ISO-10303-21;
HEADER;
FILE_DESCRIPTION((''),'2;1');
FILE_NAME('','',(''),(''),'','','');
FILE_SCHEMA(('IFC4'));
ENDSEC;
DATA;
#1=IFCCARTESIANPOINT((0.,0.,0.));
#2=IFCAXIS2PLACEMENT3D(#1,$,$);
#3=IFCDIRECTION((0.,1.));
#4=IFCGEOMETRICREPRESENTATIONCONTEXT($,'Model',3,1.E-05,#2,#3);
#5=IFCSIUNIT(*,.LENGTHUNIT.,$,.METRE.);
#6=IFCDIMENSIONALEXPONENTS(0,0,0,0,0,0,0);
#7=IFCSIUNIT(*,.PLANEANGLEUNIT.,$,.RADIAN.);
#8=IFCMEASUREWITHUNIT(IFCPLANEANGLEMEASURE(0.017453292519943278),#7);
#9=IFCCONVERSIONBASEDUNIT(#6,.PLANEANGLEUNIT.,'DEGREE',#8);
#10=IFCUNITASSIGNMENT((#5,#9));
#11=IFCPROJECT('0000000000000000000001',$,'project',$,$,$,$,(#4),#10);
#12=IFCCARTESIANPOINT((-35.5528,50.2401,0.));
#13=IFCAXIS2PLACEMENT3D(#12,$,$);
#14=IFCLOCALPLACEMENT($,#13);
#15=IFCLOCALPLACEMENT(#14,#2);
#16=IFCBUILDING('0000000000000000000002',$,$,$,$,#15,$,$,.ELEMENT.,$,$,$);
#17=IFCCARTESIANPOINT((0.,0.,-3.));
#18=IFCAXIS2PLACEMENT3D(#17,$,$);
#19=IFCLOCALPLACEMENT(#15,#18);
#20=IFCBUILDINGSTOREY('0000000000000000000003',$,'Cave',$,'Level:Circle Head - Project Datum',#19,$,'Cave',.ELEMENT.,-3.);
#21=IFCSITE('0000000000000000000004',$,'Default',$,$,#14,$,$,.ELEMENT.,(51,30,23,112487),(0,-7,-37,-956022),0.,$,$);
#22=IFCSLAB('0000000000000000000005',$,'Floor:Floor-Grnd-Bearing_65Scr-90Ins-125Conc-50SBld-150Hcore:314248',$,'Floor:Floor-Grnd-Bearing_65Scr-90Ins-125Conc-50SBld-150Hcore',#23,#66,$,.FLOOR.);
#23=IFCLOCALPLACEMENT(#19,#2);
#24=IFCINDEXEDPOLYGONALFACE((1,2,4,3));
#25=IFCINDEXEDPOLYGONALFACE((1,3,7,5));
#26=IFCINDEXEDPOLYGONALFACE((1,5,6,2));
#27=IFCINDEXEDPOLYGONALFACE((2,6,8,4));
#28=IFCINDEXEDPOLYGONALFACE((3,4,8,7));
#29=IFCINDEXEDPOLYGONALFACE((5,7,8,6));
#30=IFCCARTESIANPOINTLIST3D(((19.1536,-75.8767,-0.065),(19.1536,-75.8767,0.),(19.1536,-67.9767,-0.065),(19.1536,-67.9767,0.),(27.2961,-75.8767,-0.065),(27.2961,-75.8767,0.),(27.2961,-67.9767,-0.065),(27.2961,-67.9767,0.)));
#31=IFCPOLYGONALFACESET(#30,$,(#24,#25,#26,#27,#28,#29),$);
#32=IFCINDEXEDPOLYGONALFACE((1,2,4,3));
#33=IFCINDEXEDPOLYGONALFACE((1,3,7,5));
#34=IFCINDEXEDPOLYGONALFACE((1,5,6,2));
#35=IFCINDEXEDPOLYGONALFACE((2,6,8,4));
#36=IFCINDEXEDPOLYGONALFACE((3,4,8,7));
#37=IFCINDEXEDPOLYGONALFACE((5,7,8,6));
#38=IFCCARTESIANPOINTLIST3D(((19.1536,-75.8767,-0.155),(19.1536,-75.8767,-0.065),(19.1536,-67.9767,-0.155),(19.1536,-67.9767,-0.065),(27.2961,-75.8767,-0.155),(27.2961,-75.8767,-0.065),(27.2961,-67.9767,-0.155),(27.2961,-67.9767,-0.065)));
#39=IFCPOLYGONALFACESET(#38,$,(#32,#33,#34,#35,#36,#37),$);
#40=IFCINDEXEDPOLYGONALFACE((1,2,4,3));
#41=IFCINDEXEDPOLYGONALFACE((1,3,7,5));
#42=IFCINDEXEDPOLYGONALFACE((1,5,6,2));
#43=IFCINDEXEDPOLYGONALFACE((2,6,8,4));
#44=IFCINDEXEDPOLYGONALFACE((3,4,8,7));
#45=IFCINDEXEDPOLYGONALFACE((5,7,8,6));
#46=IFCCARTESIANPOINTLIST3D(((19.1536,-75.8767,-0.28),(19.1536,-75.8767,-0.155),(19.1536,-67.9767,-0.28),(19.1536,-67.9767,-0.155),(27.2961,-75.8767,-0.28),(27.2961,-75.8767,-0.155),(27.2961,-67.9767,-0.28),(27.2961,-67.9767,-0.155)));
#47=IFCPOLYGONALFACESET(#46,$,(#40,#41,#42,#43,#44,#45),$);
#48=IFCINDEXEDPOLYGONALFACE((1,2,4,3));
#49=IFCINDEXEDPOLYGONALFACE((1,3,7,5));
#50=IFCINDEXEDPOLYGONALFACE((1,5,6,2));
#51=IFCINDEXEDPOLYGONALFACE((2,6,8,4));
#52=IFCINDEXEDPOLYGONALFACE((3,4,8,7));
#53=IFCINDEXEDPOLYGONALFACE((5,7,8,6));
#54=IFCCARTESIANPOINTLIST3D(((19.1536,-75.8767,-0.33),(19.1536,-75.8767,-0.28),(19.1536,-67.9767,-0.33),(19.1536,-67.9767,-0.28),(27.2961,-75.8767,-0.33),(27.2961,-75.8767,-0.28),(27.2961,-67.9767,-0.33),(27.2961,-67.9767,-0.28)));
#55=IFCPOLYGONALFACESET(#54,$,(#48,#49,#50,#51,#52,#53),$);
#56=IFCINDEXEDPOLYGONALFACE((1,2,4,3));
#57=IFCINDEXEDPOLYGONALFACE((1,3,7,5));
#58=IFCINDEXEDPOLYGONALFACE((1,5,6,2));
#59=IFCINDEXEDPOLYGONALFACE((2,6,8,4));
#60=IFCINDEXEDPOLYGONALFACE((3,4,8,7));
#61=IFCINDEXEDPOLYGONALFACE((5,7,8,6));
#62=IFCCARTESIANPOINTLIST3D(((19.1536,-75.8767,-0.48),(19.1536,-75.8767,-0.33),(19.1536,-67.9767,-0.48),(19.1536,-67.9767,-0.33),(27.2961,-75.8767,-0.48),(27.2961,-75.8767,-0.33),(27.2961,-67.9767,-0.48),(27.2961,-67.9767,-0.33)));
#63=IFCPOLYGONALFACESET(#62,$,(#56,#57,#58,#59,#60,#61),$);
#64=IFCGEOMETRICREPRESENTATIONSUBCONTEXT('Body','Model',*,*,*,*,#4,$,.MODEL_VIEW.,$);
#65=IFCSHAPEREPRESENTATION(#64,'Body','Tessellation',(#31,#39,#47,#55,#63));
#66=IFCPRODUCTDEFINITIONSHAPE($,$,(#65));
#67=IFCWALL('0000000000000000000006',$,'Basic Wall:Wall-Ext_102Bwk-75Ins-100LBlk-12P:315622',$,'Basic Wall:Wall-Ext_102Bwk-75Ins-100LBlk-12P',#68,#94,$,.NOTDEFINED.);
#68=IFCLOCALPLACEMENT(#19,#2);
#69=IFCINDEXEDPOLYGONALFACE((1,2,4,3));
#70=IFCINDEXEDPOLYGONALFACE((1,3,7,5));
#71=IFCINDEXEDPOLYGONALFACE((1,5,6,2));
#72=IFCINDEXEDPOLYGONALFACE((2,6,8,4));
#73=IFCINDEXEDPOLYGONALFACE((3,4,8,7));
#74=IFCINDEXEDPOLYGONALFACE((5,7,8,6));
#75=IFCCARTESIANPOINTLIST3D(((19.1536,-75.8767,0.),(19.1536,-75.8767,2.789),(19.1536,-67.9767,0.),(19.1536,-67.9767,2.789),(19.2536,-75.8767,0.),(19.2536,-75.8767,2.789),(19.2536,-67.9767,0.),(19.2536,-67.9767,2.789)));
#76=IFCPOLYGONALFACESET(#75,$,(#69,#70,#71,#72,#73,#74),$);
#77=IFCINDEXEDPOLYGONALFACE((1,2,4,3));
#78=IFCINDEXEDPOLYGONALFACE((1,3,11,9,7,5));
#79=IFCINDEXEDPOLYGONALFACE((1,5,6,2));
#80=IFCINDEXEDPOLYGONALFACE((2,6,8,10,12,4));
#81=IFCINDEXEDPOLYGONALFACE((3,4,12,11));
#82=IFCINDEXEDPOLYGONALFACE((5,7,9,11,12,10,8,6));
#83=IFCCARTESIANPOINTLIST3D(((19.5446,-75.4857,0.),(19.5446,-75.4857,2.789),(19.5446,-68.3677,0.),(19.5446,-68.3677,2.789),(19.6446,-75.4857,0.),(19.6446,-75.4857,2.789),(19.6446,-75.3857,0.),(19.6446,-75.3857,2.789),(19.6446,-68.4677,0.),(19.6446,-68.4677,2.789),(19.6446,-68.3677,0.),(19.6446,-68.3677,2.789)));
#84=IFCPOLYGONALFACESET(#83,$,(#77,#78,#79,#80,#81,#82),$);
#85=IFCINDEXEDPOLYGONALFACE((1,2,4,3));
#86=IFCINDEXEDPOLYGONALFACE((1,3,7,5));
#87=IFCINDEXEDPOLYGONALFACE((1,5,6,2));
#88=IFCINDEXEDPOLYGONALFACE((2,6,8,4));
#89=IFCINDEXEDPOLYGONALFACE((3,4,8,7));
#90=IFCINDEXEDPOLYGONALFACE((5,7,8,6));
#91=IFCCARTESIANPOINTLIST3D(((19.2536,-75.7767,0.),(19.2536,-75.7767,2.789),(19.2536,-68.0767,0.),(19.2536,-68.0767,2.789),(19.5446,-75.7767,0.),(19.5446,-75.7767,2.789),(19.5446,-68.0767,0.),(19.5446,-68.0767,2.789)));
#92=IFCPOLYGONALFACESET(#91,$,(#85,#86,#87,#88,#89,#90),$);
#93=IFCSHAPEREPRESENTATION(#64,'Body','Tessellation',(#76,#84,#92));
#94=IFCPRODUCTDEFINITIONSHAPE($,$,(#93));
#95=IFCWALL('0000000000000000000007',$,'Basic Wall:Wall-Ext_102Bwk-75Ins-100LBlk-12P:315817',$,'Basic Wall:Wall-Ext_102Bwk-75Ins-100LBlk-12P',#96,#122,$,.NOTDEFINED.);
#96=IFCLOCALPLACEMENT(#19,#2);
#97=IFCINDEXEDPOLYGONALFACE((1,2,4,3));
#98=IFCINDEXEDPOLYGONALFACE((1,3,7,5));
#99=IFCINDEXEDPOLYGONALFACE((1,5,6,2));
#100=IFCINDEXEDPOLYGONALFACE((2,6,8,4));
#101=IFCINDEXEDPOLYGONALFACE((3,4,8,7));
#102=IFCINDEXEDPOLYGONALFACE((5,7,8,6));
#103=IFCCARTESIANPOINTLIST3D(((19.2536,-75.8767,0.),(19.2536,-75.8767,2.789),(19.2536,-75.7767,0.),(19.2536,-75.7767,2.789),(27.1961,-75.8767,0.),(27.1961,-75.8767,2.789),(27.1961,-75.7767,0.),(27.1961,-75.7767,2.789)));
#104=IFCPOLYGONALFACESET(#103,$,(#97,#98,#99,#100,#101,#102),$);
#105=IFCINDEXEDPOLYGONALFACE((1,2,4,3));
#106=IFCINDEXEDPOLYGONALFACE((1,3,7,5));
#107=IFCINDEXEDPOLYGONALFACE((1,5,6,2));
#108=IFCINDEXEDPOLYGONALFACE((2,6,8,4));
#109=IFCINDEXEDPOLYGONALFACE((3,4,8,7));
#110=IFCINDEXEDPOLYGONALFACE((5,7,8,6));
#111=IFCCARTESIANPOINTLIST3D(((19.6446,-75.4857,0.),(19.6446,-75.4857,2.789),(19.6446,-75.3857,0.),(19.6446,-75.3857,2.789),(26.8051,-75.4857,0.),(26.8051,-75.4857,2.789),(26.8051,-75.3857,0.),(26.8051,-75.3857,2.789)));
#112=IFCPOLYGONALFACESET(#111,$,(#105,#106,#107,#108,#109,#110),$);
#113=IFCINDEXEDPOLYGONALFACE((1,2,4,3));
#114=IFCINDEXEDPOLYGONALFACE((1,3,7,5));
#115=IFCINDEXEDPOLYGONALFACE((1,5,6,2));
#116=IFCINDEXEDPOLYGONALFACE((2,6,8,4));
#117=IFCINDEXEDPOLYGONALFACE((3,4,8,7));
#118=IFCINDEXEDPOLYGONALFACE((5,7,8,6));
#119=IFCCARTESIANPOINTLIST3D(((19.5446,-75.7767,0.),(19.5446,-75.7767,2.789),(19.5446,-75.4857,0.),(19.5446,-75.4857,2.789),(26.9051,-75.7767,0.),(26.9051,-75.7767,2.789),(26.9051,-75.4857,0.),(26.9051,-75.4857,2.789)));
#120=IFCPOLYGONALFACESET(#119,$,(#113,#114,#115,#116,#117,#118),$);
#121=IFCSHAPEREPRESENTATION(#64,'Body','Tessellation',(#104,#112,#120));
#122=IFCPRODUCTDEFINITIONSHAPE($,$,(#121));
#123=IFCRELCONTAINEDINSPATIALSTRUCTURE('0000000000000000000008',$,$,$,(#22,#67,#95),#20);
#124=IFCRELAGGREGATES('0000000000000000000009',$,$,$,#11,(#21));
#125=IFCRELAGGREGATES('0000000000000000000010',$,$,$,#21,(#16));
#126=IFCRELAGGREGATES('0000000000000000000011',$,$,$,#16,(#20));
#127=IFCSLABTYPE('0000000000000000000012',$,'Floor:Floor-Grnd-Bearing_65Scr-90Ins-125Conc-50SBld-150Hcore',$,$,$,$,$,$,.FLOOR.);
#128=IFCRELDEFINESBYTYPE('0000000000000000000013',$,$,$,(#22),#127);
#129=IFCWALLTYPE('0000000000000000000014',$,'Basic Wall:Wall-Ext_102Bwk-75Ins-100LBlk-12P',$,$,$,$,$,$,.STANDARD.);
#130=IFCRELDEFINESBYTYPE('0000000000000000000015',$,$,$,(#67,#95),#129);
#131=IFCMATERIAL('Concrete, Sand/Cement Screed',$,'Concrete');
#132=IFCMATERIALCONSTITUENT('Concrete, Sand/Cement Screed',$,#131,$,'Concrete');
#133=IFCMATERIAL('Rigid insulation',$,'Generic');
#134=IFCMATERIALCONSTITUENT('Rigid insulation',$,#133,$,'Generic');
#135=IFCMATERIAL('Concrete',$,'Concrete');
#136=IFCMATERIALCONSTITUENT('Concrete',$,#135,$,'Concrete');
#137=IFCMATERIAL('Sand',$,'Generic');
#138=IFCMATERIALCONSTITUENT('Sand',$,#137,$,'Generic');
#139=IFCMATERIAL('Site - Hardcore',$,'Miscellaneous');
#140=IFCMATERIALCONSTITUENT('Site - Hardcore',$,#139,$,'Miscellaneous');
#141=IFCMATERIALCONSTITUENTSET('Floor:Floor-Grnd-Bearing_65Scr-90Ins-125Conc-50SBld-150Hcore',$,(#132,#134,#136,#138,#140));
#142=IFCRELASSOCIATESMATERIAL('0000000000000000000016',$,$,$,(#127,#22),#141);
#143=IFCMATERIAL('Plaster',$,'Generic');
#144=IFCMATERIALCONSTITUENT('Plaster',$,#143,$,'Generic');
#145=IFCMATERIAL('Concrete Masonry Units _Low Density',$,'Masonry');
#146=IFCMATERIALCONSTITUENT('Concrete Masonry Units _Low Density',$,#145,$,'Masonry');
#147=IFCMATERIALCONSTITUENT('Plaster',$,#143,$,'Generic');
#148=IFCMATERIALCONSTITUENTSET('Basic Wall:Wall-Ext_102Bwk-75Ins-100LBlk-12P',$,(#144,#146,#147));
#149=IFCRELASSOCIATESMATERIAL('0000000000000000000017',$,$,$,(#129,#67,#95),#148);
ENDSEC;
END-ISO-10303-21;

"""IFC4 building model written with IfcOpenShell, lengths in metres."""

from ifc_helpers import new_model, entity, si_unit, converted_unit, direction, frame, origin, place, context, subcontext, project, spatial, indexed_curve, outline, extrude, material, constituent, constituent_set, type_object, element, save


model = new_model("IFC4")

# Units and contexts
model_context = context("Model", 3, precision=1e-05, world=origin(), true_north=direction((0.0, 1.0)))
body_context = subcontext(model_context, "Body", "Model", "MODEL_VIEW")
ifc_project = project(units=[si_unit("LENGTHUNIT", "METRE"), converted_unit("PLANEANGLEUNIT", "DEGREE", entity("IfcPlaneAngleMeasure", 0.017453292519943278), si_unit("PLANEANGLEUNIT", "RADIAN"), dimensions=[0, 0, 0, 0, 0, 0, 0])], contexts=[model_context])

# Site, building, storey
site_placement = place(None, frame((-35.5528, 50.2401, 0.0)))
site = spatial("IfcSite", under=ifc_project, at=site_placement, Name="Default", CompositionType="ELEMENT", RefLatitude=(51, 30, 23, 112487), RefLongitude=(0, -7, -37, -956022), RefElevation=0.0)
building_placement = place(site_placement, origin())
building = spatial("IfcBuilding", under=site, at=building_placement, CompositionType="ELEMENT")
storey_placement = place(building_placement, frame((0.0, 0.0, -3.0)))
storey = spatial("IfcBuildingStorey", under=building, at=storey_placement, Name="Cave", ObjectType="Level:Circle Head - Project Datum", LongName="Cave", CompositionType="ELEMENT", Elevation=-3.0)

# Slab
ifc_material_1 = material(Name="Concrete, Sand/Cement Screed", Category="Concrete")
ifc_constituent_1 = constituent(ifc_material_1, Name="Concrete, Sand/Cement Screed", Category="Concrete")
ifc_material_2 = material(Name="Rigid insulation", Category="Generic")
ifc_constituent_2 = constituent(ifc_material_2, Name="Rigid insulation", Category="Generic")
ifc_material_3 = material(Name="Concrete", Category="Concrete")
ifc_constituent_3 = constituent(ifc_material_3, Name="Concrete", Category="Concrete")
ifc_material_4 = material(Name="Sand", Category="Generic")
ifc_constituent_4 = constituent(ifc_material_4, Name="Sand", Category="Generic")
ifc_material_5 = material(Name="Site - Hardcore", Category="Miscellaneous")
ifc_constituent_5 = constituent(ifc_material_5, Name="Site - Hardcore", Category="Miscellaneous")
ifc_constituent_set_1 = constituent_set(constituents=[ifc_constituent_1, ifc_constituent_2, ifc_constituent_3, ifc_constituent_4, ifc_constituent_5], Name="Floor:Floor-Grnd-Bearing_65Scr-90Ins-125Conc-50SBld-150Hcore")
slab_type = type_object("IfcSlabType", Name="Floor:Floor-Grnd-Bearing_65Scr-90Ins-125Conc-50SBld-150Hcore", PredefinedType="FLOOR", material=ifc_constituent_set_1)
slab_placement = place(storey_placement, origin())
element("IfcSlab", 1, at=slab_placement, inside=storey, type_object=slab_type, material=ifc_constituent_set_1, Name="Floor:Floor-Grnd-Bearing_65Scr-90Ins-125Conc-50SBld-150Hcore:314248", ObjectType="Floor:Floor-Grnd-Bearing_65Scr-90Ins-125Conc-50SBld-150Hcore", PredefinedType="FLOOR", context=body_context, shape_type="SweptSolid", body=[
    extrude(outline(indexed_curve([(-4.0712, -3.95), (4.0712, -3.95), (4.0712, 3.95), (-4.0712, 3.95), (-4.0712, -3.95)], self_intersect=False)), frame((23.2249, -71.9267, -0.065), z_axis=(0.0, 0.0, 1.0), x_axis=(-1.0, 0.0, 0.0)), (0.0, 0.0, 1.0), 0.065),
    extrude(outline(indexed_curve([(-4.0712, -3.95), (4.0712, -3.95), (4.0712, 3.95), (-4.0712, 3.95), (-4.0712, -3.95)], self_intersect=False)), frame((23.2249, -71.9267, -0.155), z_axis=(0.0, 0.0, 1.0), x_axis=(-1.0, 0.0, 0.0)), (0.0, 0.0, 1.0), 0.09),
    extrude(outline(indexed_curve([(-4.0713, -3.95), (4.0712, -3.95), (4.0712, 3.95), (-4.0713, 3.95), (-4.0713, -3.95)], self_intersect=False)), frame((23.2249, -71.9267, -0.28), z_axis=(0.0, 0.0, 1.0), x_axis=(-1.0, 0.0, 0.0)), (0.0, 0.0, 1.0), 0.125),
    extrude(outline(indexed_curve([(-4.0712, -3.95), (4.0712, -3.95), (4.0712, 3.95), (-4.0712, 3.95), (-4.0712, -3.95)], self_intersect=False)), frame((23.2249, -71.9267, -0.33), z_axis=(0.0, 0.0, 1.0), x_axis=(-1.0, 0.0, 0.0)), (0.0, 0.0, 1.0), 0.05),
    extrude(outline(indexed_curve([(-4.0712, -3.95), (4.0712, -3.95), (4.0712, 3.95), (-4.0712, 3.95), (-4.0712, -3.95)], self_intersect=False)), frame((23.2249, -71.9267, -0.48), z_axis=(0.0, 0.0, 1.0), x_axis=(-1.0, 0.0, 0.0)), (0.0, 0.0, 1.0), 0.15),
])

# Walls
ifc_material_6 = material(Name="Plaster", Category="Generic")
ifc_constituent_6 = constituent(ifc_material_6, Name="Plaster", Category="Generic")
ifc_material_7 = material(Name="Concrete Masonry Units _Low Density", Category="Masonry")
ifc_constituent_7 = constituent(ifc_material_7, Name="Concrete Masonry Units _Low Density", Category="Masonry")
ifc_constituent_8 = constituent(ifc_material_6, Name="Plaster", Category="Generic")
ifc_constituent_set_2 = constituent_set(constituents=[ifc_constituent_6, ifc_constituent_7, ifc_constituent_8], Name="Basic Wall:Wall-Ext_102Bwk-75Ins-100LBlk-12P")
wall_type_1 = type_object("IfcWallType", Name="Basic Wall:Wall-Ext_102Bwk-75Ins-100LBlk-12P", PredefinedType="STANDARD", material=ifc_constituent_set_2)
wall_1_placement = place(storey_placement, frame((19.3991, -75.8767, 0.0), z_axis=(0.0, 0.0, 1.0), x_axis=(0.0, 1.0, 0.0)))
element("IfcWall", 2, at=wall_1_placement, inside=storey, type_object=wall_type_1, material=ifc_constituent_set_2, Name="Basic Wall:Wall-Ext_102Bwk-75Ins-100LBlk-12P:315622", ObjectType="Basic Wall:Wall-Ext_102Bwk-75Ins-100LBlk-12P", PredefinedType="NOTDEFINED", context=body_context, shape_type="SweptSolid", body=[
    extrude(outline(indexed_curve([(-0.05, -3.95), (0.05, -3.95), (0.05, 3.95), (-0.05, 3.95), (-0.05, -3.95)], self_intersect=False)), frame((3.95, 0.1955, 0.0), z_axis=(0.0, 0.0, 1.0), x_axis=(0.0, -1.0, 0.0)), (0.0, 0.0, 1.0), 2.789),
    extrude(outline(indexed_curve([(-3.459, -0.0333), (3.459, -0.0333), (3.559, -0.0333), (3.559, 0.0667), (-3.559, 0.0667), (-3.559, -0.0333), (-3.459, -0.0333)], self_intersect=False)), frame((3.95, -0.2122, 0.0)), (0.0, 0.0, 1.0), 2.789),
    extrude(outline(indexed_curve([(-3.85, -0.1455), (3.85, -0.1455), (3.85, 0.1455), (-3.85, 0.1455), (-3.85, -0.1455)], self_intersect=False)), frame((3.95, 0.0, 0.0)), (0.0, 0.0, 1.0), 2.789),
])
wall_2_placement = place(storey_placement, frame((26.8051, -75.6312, 0.0), z_axis=(0.0, 0.0, 1.0), x_axis=(-1.0, 0.0, 0.0)))
element("IfcWall", 3, at=wall_2_placement, inside=storey, type_object=wall_type_1, material=ifc_constituent_set_2, Name="Basic Wall:Wall-Ext_102Bwk-75Ins-100LBlk-12P:315817", ObjectType="Basic Wall:Wall-Ext_102Bwk-75Ins-100LBlk-12P", PredefinedType="NOTDEFINED", context=body_context, shape_type="SweptSolid", body=[
    extrude(outline(indexed_curve([(-0.05, -1.3945), (0.05, -1.3945), (0.05, 1.3945), (-0.05, 1.3945), (-0.05, -1.3945)], self_intersect=False)), frame((7.5515, 0.1955, 1.3945), z_axis=(-1.0, 0.0, 0.0), x_axis=(0.0, -1.0, 0.0)), (0.0, 0.0, 1.0), 7.9425),
    extrude(outline(indexed_curve([(-0.05, -1.3945), (0.05, -1.3945), (0.05, 1.3945), (-0.05, 1.3945), (-0.05, -1.3945)], self_intersect=False)), frame((7.1605, -0.1955, 1.3945), z_axis=(-1.0, 0.0, 0.0), x_axis=(0.0, 1.0, 0.0)), (0.0, 0.0, 1.0), 7.1605),
    extrude(outline(indexed_curve([(-1.3945, -0.1455), (1.3945, -0.1455), (1.3945, 0.1455), (-1.3945, 0.1455), (-1.3945, -0.1455)], self_intersect=False)), frame((7.2605, 0.0, 1.3945), z_axis=(-1.0, 0.0, 0.0), x_axis=(0.0, 0.0, 1.0)), (0.0, 0.0, 1.0), 7.3605),
])

save(model, "model.ifc")
